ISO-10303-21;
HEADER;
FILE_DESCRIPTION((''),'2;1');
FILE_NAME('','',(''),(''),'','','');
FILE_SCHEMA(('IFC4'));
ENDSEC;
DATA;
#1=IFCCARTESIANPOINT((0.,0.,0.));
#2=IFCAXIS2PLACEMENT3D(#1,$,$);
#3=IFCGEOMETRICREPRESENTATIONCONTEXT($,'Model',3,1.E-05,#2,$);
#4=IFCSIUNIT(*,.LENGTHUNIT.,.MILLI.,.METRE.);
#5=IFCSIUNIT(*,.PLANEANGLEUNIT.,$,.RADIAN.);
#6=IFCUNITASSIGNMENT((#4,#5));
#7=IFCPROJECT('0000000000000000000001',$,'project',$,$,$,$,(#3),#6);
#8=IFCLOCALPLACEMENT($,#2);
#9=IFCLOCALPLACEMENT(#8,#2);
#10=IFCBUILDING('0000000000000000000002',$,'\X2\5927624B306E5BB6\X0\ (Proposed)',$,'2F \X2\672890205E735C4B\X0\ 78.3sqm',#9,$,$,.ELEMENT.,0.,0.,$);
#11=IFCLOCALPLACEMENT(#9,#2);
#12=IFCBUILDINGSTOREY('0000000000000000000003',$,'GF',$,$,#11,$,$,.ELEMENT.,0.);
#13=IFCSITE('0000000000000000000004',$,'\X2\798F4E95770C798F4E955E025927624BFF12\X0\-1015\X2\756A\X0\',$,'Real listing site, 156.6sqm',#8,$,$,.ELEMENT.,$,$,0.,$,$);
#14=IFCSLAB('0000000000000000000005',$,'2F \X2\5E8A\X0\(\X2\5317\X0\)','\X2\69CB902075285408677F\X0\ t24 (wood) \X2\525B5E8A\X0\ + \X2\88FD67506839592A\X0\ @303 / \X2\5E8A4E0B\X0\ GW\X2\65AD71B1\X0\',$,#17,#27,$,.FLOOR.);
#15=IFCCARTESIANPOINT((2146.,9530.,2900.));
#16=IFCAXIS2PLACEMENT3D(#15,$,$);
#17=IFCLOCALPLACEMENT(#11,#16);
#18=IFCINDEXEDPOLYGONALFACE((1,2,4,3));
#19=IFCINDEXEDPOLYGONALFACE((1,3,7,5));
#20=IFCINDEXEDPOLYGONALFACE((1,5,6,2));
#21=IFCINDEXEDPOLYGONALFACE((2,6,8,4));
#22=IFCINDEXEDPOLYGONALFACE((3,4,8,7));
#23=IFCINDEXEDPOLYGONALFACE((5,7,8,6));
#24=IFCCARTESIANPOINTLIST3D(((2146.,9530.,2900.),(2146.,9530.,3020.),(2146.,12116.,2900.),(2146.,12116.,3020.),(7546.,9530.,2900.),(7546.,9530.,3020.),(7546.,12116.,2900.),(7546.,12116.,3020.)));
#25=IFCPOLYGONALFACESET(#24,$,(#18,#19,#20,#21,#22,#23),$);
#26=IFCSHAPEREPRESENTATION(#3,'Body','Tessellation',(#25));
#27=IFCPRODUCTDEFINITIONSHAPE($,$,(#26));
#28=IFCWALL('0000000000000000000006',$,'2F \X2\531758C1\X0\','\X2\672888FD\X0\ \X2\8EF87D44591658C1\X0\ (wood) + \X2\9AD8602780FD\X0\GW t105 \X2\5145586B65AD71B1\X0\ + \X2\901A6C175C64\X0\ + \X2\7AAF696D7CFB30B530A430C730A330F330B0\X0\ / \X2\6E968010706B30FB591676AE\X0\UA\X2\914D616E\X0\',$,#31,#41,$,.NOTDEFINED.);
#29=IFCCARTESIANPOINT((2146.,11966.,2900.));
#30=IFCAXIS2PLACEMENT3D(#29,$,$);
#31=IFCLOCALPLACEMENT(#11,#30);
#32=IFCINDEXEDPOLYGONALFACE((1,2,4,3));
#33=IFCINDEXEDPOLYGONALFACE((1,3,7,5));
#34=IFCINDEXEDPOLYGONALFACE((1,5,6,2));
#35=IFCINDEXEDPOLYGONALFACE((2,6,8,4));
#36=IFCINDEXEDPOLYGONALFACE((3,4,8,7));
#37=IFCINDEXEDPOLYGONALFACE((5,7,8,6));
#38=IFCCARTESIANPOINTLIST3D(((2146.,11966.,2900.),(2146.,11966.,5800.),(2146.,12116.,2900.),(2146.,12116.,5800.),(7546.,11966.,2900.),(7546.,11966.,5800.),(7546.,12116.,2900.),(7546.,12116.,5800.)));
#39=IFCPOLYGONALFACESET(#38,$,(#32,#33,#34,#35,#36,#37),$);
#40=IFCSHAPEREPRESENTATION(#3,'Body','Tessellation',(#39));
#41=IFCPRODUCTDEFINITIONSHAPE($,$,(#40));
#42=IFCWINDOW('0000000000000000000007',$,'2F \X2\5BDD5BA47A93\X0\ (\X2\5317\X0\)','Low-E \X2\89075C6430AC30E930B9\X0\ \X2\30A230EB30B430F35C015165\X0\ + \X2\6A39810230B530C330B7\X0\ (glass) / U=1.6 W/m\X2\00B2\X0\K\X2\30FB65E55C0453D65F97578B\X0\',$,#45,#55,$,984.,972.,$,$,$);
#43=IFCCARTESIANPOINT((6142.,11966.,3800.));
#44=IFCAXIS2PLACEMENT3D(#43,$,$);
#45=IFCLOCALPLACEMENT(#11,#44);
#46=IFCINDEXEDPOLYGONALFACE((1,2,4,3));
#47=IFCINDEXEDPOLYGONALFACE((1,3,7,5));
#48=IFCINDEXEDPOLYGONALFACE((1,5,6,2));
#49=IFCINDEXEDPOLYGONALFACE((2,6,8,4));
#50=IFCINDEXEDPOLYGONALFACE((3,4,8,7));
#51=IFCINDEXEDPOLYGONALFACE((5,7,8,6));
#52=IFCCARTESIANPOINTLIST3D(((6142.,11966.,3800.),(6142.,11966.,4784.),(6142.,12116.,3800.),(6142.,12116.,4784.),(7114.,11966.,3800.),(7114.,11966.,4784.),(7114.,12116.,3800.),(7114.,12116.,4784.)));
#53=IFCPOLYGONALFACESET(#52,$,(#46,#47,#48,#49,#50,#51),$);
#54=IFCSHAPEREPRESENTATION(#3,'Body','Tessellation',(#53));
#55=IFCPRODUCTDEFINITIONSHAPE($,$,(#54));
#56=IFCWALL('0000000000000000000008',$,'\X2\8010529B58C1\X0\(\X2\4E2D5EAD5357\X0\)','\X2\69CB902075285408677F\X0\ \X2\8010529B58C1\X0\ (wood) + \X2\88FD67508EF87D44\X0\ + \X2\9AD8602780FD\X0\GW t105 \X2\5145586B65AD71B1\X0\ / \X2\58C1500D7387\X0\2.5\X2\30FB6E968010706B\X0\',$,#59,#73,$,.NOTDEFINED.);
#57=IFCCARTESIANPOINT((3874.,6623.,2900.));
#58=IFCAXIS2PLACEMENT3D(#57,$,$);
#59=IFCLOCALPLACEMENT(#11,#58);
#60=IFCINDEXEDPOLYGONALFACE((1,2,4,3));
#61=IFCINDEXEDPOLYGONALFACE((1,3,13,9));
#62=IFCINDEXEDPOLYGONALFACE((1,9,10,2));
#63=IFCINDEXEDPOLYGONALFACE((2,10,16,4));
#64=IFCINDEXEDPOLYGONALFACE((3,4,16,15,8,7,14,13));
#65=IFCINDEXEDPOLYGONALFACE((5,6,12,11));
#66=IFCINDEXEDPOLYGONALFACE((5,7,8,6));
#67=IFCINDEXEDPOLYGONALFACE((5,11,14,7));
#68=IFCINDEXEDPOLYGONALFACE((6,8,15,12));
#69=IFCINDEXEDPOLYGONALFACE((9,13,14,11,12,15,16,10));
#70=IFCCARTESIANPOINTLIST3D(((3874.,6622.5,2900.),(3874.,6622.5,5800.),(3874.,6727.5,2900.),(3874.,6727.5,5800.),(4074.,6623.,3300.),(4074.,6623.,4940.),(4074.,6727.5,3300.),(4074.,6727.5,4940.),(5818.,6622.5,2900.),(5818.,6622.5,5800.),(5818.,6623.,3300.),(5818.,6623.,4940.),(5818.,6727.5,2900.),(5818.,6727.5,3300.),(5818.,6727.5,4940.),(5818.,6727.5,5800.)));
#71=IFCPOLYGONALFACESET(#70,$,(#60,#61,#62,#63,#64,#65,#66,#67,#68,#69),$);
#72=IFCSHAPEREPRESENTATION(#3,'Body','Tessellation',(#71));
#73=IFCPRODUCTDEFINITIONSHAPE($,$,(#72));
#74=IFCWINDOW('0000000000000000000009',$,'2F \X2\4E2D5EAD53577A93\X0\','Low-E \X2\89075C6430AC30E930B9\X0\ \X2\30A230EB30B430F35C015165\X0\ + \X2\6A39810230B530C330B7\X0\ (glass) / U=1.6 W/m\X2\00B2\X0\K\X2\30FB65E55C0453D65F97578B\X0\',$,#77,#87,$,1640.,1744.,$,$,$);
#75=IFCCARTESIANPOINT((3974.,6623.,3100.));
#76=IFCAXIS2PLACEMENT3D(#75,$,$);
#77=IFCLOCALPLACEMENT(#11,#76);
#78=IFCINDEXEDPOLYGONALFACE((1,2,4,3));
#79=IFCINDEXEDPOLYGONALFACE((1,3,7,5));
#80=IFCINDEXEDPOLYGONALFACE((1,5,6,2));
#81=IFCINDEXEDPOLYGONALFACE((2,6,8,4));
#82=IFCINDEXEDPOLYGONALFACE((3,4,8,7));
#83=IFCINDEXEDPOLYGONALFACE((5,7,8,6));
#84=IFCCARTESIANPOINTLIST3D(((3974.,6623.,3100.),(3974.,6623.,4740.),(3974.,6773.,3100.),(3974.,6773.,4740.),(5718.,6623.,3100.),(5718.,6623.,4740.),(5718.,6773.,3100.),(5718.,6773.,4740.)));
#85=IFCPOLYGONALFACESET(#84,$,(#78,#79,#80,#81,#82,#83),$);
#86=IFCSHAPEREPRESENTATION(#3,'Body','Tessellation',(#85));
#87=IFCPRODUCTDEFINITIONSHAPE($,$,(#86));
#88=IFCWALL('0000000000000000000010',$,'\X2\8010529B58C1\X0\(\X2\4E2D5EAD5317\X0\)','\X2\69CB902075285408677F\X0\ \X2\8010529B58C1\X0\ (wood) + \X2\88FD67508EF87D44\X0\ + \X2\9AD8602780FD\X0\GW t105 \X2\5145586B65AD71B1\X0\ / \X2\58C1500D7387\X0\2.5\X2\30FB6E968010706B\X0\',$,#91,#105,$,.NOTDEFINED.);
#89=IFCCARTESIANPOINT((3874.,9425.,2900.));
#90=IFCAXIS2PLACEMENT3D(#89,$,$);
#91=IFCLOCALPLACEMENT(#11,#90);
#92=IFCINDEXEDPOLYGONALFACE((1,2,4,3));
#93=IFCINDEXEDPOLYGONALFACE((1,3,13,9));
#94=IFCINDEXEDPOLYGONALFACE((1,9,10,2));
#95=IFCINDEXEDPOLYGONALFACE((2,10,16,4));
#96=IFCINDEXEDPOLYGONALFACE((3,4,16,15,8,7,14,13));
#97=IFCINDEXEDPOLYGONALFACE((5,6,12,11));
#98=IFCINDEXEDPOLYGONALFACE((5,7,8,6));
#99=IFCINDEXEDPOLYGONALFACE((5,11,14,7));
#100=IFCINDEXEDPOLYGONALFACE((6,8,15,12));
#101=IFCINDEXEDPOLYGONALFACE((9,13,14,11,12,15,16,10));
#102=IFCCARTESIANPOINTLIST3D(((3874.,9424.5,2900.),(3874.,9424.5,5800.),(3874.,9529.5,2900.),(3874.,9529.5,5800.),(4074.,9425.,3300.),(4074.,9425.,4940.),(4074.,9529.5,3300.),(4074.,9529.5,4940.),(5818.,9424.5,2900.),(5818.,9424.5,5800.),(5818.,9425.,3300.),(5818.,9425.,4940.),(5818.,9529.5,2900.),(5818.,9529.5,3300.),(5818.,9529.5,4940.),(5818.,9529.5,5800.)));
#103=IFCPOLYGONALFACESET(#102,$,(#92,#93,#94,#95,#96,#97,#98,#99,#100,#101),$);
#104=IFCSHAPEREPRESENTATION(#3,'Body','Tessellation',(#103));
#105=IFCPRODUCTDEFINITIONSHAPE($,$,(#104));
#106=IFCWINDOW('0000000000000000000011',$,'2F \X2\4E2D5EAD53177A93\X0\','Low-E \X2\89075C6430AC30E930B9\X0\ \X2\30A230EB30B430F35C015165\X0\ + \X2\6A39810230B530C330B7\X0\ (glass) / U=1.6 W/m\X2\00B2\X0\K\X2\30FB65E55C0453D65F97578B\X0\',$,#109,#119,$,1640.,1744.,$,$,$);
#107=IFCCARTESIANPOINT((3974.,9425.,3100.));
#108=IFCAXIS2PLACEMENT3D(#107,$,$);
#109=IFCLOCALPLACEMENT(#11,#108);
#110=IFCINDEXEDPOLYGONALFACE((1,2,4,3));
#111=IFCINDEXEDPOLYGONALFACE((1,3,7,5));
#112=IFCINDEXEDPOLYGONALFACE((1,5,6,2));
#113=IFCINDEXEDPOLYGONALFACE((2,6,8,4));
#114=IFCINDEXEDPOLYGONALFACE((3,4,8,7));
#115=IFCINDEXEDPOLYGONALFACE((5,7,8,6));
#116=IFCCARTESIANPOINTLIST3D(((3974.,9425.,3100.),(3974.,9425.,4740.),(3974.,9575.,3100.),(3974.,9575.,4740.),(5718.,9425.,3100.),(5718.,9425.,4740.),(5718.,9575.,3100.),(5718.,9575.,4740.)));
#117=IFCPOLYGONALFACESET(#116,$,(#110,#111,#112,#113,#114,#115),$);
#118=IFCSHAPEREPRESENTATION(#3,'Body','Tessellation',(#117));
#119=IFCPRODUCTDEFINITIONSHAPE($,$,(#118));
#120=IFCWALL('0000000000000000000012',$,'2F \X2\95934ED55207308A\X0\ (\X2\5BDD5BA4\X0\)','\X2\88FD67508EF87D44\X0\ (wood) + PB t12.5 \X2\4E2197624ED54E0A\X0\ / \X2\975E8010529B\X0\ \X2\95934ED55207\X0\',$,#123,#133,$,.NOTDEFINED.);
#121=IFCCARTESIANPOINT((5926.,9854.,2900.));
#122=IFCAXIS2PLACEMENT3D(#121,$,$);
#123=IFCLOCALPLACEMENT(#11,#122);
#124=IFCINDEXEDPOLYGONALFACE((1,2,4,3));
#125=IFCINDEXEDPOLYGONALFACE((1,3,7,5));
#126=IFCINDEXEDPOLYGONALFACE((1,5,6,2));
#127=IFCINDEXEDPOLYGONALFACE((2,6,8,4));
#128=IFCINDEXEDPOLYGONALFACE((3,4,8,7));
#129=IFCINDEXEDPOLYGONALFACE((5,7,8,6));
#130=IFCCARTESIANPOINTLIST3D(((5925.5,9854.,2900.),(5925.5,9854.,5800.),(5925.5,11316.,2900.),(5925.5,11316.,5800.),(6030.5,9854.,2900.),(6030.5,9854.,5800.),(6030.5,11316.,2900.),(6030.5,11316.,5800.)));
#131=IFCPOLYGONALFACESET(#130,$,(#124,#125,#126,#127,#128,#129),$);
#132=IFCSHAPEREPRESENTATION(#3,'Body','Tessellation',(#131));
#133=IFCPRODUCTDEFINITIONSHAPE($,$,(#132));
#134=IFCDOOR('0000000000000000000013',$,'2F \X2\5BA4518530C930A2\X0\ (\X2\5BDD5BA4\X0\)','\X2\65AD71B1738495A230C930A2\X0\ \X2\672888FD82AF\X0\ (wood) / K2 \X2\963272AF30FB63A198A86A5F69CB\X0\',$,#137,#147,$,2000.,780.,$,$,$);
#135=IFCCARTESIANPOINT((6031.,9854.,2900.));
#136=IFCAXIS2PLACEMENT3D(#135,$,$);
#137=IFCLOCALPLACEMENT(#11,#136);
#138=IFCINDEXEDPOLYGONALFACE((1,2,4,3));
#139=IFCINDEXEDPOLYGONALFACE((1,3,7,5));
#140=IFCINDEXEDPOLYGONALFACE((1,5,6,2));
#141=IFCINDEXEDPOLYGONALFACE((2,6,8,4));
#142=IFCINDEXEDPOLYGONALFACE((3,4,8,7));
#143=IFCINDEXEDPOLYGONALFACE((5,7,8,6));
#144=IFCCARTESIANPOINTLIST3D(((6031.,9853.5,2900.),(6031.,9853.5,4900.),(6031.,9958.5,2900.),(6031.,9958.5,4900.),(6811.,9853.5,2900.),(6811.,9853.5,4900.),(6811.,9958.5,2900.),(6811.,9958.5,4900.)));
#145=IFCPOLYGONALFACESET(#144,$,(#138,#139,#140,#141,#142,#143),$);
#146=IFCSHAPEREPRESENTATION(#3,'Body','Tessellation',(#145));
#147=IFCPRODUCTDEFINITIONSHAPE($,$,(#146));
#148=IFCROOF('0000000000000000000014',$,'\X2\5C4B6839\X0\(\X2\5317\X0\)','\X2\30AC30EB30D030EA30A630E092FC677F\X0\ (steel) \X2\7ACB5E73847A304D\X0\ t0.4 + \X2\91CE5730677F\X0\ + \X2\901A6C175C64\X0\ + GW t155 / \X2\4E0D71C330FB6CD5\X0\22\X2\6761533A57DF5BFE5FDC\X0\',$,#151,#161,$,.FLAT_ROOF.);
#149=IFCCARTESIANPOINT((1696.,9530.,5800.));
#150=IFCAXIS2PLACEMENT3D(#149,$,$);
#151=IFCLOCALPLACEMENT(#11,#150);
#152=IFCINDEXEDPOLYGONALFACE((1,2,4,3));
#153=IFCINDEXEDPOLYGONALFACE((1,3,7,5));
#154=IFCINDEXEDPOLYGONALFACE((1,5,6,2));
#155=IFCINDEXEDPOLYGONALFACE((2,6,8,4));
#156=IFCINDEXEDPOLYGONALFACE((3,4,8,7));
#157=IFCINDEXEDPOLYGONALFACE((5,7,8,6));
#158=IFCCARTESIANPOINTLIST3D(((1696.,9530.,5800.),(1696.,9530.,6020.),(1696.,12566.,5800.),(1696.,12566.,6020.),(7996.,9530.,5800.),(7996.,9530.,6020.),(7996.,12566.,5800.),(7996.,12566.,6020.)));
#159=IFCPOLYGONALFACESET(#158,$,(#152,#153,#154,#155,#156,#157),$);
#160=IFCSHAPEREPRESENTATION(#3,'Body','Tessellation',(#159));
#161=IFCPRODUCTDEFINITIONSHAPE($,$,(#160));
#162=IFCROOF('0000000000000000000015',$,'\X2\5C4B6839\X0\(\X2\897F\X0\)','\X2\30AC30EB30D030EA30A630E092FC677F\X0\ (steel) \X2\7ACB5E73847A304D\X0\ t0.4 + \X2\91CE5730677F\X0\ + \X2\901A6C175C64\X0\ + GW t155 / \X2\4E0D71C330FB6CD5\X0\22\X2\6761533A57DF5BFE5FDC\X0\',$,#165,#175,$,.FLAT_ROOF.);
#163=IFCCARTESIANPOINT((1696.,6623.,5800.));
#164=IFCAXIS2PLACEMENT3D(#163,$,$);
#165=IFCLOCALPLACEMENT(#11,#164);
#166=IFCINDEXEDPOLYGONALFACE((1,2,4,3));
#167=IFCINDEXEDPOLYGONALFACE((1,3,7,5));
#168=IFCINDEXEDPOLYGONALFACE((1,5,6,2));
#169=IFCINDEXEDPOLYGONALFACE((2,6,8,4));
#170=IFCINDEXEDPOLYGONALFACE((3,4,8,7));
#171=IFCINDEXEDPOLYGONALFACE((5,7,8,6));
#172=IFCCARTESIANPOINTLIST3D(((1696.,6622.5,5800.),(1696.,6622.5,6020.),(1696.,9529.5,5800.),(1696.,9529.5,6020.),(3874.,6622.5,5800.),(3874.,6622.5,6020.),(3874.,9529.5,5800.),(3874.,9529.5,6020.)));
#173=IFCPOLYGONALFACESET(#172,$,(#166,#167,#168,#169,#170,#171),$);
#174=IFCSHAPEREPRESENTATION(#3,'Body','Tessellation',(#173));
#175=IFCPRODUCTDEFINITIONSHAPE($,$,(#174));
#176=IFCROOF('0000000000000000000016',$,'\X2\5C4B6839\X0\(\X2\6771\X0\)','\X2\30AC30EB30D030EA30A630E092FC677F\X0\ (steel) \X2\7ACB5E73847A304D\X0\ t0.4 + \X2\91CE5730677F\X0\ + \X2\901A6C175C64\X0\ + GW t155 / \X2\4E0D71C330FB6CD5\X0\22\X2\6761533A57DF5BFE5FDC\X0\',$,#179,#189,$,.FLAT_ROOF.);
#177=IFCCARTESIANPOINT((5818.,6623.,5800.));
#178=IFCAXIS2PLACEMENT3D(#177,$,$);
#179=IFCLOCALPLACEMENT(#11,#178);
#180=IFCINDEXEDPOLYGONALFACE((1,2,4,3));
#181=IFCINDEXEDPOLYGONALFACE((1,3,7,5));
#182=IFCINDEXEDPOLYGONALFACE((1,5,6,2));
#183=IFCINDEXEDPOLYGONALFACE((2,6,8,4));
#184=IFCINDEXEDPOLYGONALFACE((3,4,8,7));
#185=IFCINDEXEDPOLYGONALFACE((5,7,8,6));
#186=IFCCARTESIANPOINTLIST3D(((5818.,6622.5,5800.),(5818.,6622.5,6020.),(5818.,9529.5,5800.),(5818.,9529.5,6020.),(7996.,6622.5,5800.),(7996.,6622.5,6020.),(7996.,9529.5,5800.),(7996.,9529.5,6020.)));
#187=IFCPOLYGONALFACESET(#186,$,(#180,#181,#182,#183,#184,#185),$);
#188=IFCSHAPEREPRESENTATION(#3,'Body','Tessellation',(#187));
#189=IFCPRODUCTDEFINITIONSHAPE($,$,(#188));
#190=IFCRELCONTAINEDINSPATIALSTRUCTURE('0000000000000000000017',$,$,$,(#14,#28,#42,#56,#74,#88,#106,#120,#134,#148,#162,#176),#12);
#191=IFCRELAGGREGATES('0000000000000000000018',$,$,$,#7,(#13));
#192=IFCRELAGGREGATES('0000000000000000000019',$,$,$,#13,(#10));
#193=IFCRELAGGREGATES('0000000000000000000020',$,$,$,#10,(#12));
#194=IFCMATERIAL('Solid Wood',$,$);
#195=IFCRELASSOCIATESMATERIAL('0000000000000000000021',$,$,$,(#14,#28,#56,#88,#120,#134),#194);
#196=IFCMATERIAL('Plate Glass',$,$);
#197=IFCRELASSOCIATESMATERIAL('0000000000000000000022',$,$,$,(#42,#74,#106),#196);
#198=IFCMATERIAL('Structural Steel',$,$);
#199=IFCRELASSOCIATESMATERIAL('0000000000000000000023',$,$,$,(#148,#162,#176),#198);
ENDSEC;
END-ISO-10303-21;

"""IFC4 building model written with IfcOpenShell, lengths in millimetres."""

from ifc_helpers import new_model, si_unit, frame, frame_2d, origin, place, context, project, spatial, rectangle, extrude, material, element, fill, save


model = new_model("IFC4")

# Units and contexts
model_context = context("Model", 3, precision=1e-05, world=origin())
ifc_project = project(units=[si_unit("LENGTHUNIT", "METRE", prefix="MILLI"), si_unit("PLANEANGLEUNIT", "RADIAN")], contexts=[model_context])

# Site, building, storey
site_placement = place(None, origin())
site = spatial("IfcSite", under=ifc_project, at=site_placement, Name="福井県福井市大手２-1015番", ObjectType="Real listing site, 156.6sqm", CompositionType="ELEMENT", RefElevation=0.0)
building_placement = place(site_placement, origin())
building = spatial("IfcBuilding", under=site, at=building_placement, Name="大手の家 (Proposed)", ObjectType="2F 木造平屋 78.3sqm", CompositionType="ELEMENT", ElevationOfRefHeight=0.0, ElevationOfTerrain=0.0)
storey_placement = place(building_placement, origin())
storey = spatial("IfcBuildingStorey", under=building, at=storey_placement, Name="GF", CompositionType="ELEMENT", Elevation=0.0)

# Slab
ifc_material_1 = material(Name="Solid Wood")
slab_placement = place(storey_placement, frame((2146.0, 9530.0, 2900.0)))
element("IfcSlab", 1, at=slab_placement, inside=storey, material=ifc_material_1, Name="2F 床(北)", Description="構造用合板 t24 (wood) 剛床 + 製材根太 @303 / 床下 GW断熱", PredefinedType="FLOOR", context=model_context, shape_type="SweptSolid", body=[
    extrude(rectangle(XDim=5400.0, YDim=2586.0, at=frame_2d((2700.0, 1293.0))), frame((2146.0, 9530.0, 2900.0)), (0.0, 0.0, 1.0), 120.0),
])

# Walls, openings, windows
wall_1_placement = place(storey_placement, frame((2146.0, 11966.0, 2900.0)))
wall_1 = element("IfcWall", 2, at=wall_1_placement, inside=storey, material=ifc_material_1, Name="2F 北壁", Description="木製 軸組外壁 (wood) + 高性能GW t105 充填断熱 + 通気層 + 窯業系サイディング / 準耐火・外皮UA配慮", PredefinedType="NOTDEFINED", context=model_context, shape_type="SweptSolid", body=[
    extrude(rectangle(XDim=5400.0, YDim=150.0, at=frame_2d((2700.0, 75.0))), frame((2146.0, 11966.0, 2900.0)), (0.0, 0.0, 1.0), 2900.0),
])
opening_1_placement = place(storey_placement, frame((6142.0, 11966.0, 3800.0)))
opening_1 = element("IfcOpeningElement", 3, at=opening_1_placement, cuts=wall_1, PredefinedType="NOTDEFINED", context=model_context, shape_type="SweptSolid", body=[
    extrude(rectangle(XDim=972.0, YDim=150.0, at=frame_2d((486.0, 75.0))), frame((6142.0, 11966.0, 3800.0)), (0.0, 0.0, 1.0), 984.0),
])
ifc_material_2 = material(Name="Plate Glass")
window_1_placement = place(storey_placement, frame((6142.0, 11966.0, 3800.0)))
window_1 = element("IfcWindow", 4, at=window_1_placement, inside=storey, material=ifc_material_2, Name="2F 寝室窓 (北)", Description="Low-E 複層ガラス アルゴン封入 + 樹脂サッシ (glass) / U=1.6 W/m²K・日射取得型", OverallHeight=984.0, OverallWidth=972.0, context=model_context, shape_type="SweptSolid", body=[
    extrude(rectangle(XDim=972.0, YDim=150.0, at=frame_2d((486.0, 75.0))), frame((6142.0, 11966.0, 3800.0)), (0.0, 0.0, 1.0), 984.0),
])
fill(opening_1, window_1)
wall_2_placement = place(storey_placement, frame((3874.0, 6623.0, 2900.0)))
wall_2 = element("IfcWall", 5, at=wall_2_placement, inside=storey, material=ifc_material_1, Name="耐力壁(中庭南)", Description="構造用合板 耐力壁 (wood) + 製材軸組 + 高性能GW t105 充填断熱 / 壁倍率2.5・準耐火", PredefinedType="NOTDEFINED", context=model_context, shape_type="SweptSolid", body=[
    extrude(rectangle(XDim=1944.0, YDim=105.0, at=frame_2d((972.0, 52.0))), frame((3874.0, 6623.0, 2900.0)), (0.0, 0.0, 1.0), 2900.0),
])
opening_2_placement = place(storey_placement, frame((3974.0, 6623.0, 3100.0)))
opening_2 = element("IfcOpeningElement", 6, at=opening_2_placement, cuts=wall_2, PredefinedType="NOTDEFINED", context=model_context, shape_type="SweptSolid", body=[
    extrude(rectangle(XDim=1744.0, YDim=150.0, at=frame_2d((872.0, 75.0))), frame((3974.0, 6623.0, 3100.0)), (0.0, 0.0, 1.0), 1640.0),
])
window_2_placement = place(storey_placement, frame((3974.0, 6623.0, 3100.0)))
window_2 = element("IfcWindow", 7, at=window_2_placement, inside=storey, material=ifc_material_2, Name="2F 中庭南窓", Description="Low-E 複層ガラス アルゴン封入 + 樹脂サッシ (glass) / U=1.6 W/m²K・日射取得型", OverallHeight=1640.0, OverallWidth=1744.0, context=model_context, shape_type="SweptSolid", body=[
    extrude(rectangle(XDim=1744.0, YDim=150.0, at=frame_2d((872.0, 75.0))), frame((3974.0, 6623.0, 3100.0)), (0.0, 0.0, 1.0), 1640.0),
])
fill(opening_2, window_2)
wall_3_placement = place(storey_placement, frame((3874.0, 9425.0, 2900.0)))
wall_3 = element("IfcWall", 8, at=wall_3_placement, inside=storey, material=ifc_material_1, Name="耐力壁(中庭北)", Description="構造用合板 耐力壁 (wood) + 製材軸組 + 高性能GW t105 充填断熱 / 壁倍率2.5・準耐火", PredefinedType="NOTDEFINED", context=model_context, shape_type="SweptSolid", body=[
    extrude(rectangle(XDim=1944.0, YDim=105.0, at=frame_2d((972.0, 52.0))), frame((3874.0, 9425.0, 2900.0)), (0.0, 0.0, 1.0), 2900.0),
])
opening_3_placement = place(storey_placement, frame((3974.0, 9425.0, 3100.0)))
opening_3 = element("IfcOpeningElement", 9, at=opening_3_placement, cuts=wall_3, PredefinedType="NOTDEFINED", context=model_context, shape_type="SweptSolid", body=[
    extrude(rectangle(XDim=1744.0, YDim=150.0, at=frame_2d((872.0, 75.0))), frame((3974.0, 9425.0, 3100.0)), (0.0, 0.0, 1.0), 1640.0),
])
window_3_placement = place(storey_placement, frame((3974.0, 9425.0, 3100.0)))
window_3 = element("IfcWindow", 10, at=window_3_placement, inside=storey, material=ifc_material_2, Name="2F 中庭北窓", Description="Low-E 複層ガラス アルゴン封入 + 樹脂サッシ (glass) / U=1.6 W/m²K・日射取得型", OverallHeight=1640.0, OverallWidth=1744.0, context=model_context, shape_type="SweptSolid", body=[
    extrude(rectangle(XDim=1744.0, YDim=150.0, at=frame_2d((872.0, 75.0))), frame((3974.0, 9425.0, 3100.0)), (0.0, 0.0, 1.0), 1640.0),
])
fill(opening_3, window_3)

# Wall
wall_4_placement = place(storey_placement, frame((5926.0, 9854.0, 2900.0)))
element("IfcWall", 11, at=wall_4_placement, inside=storey, material=ifc_material_1, Name="2F 間仕切り (寝室)", Description="製材軸組 (wood) + PB t12.5 両面仕上 / 非耐力 間仕切", PredefinedType="NOTDEFINED", context=model_context, shape_type="SweptSolid", body=[
    extrude(rectangle(XDim=105.0, YDim=1462.0, at=frame_2d((52.0, 731.0))), frame((5926.0, 9854.0, 2900.0)), (0.0, 0.0, 1.0), 2900.0),
])

# Door
door_placement = place(storey_placement, frame((6031.0, 9854.0, 2900.0)))
element("IfcDoor", 12, at=door_placement, inside=storey, material=ifc_material_1, Name="2F 室内ドア (寝室)", Description="断熱玄関ドア 木製芯 (wood) / K2 防犯・採風機構", OverallHeight=2000.0, OverallWidth=780.0, context=model_context, shape_type="SweptSolid", body=[
    extrude(rectangle(XDim=780.0, YDim=105.0, at=frame_2d((390.0, 52.0))), frame((6031.0, 9854.0, 2900.0)), (0.0, 0.0, 1.0), 2000.0),
])

# Roofs
ifc_material_3 = material(Name="Structural Steel")
for number, where, name in (
    (13, (1696.0, 9530.0, 5800.0), "屋根(北)"),
):
    element("IfcRoof", number, at=place(storey_placement, frame(where)), inside=storey, material=ifc_material_3, Name=name, Description="ガルバリウム鋼板 (steel) 立平葺き t0.4 + 野地板 + 通気層 + GW t155 / 不燃・法22条区域対応", PredefinedType="FLAT_ROOF", context=model_context, shape_type="SweptSolid", body=[
        extrude(rectangle(XDim=6300.0, YDim=3036.0, at=frame_2d((3150.0, 1518.0))), frame((1696.0, 9530.0, 5800.0)), (0.0, 0.0, 1.0), 220.0),
    ])
roof_1_placement = place(storey_placement, frame((1696.0, 6623.0, 5800.0)))
element("IfcRoof", 14, at=roof_1_placement, inside=storey, material=ifc_material_3, Name="屋根(西)", Description="ガルバリウム鋼板 (steel) 立平葺き t0.4 + 野地板 + 通気層 + GW t155 / 不燃・法22条区域対応", PredefinedType="FLAT_ROOF", context=model_context, shape_type="SweptSolid", body=[
    extrude(rectangle(XDim=2178.0, YDim=2907.0, at=frame_2d((1089.0, 1453.0))), frame((1696.0, 6623.0, 5800.0)), (0.0, 0.0, 1.0), 220.0),
])
roof_2_placement = place(storey_placement, frame((5818.0, 6623.0, 5800.0)))
element("IfcRoof", 15, at=roof_2_placement, inside=storey, material=ifc_material_3, Name="屋根(東)", Description="ガルバリウム鋼板 (steel) 立平葺き t0.4 + 野地板 + 通気層 + GW t155 / 不燃・法22条区域対応", PredefinedType="FLAT_ROOF", context=model_context, shape_type="SweptSolid", body=[
    extrude(rectangle(XDim=2178.0, YDim=2907.0, at=frame_2d((1089.0, 1453.0))), frame((5818.0, 6623.0, 5800.0)), (0.0, 0.0, 1.0), 220.0),
])

save(model, "model.ifc")
